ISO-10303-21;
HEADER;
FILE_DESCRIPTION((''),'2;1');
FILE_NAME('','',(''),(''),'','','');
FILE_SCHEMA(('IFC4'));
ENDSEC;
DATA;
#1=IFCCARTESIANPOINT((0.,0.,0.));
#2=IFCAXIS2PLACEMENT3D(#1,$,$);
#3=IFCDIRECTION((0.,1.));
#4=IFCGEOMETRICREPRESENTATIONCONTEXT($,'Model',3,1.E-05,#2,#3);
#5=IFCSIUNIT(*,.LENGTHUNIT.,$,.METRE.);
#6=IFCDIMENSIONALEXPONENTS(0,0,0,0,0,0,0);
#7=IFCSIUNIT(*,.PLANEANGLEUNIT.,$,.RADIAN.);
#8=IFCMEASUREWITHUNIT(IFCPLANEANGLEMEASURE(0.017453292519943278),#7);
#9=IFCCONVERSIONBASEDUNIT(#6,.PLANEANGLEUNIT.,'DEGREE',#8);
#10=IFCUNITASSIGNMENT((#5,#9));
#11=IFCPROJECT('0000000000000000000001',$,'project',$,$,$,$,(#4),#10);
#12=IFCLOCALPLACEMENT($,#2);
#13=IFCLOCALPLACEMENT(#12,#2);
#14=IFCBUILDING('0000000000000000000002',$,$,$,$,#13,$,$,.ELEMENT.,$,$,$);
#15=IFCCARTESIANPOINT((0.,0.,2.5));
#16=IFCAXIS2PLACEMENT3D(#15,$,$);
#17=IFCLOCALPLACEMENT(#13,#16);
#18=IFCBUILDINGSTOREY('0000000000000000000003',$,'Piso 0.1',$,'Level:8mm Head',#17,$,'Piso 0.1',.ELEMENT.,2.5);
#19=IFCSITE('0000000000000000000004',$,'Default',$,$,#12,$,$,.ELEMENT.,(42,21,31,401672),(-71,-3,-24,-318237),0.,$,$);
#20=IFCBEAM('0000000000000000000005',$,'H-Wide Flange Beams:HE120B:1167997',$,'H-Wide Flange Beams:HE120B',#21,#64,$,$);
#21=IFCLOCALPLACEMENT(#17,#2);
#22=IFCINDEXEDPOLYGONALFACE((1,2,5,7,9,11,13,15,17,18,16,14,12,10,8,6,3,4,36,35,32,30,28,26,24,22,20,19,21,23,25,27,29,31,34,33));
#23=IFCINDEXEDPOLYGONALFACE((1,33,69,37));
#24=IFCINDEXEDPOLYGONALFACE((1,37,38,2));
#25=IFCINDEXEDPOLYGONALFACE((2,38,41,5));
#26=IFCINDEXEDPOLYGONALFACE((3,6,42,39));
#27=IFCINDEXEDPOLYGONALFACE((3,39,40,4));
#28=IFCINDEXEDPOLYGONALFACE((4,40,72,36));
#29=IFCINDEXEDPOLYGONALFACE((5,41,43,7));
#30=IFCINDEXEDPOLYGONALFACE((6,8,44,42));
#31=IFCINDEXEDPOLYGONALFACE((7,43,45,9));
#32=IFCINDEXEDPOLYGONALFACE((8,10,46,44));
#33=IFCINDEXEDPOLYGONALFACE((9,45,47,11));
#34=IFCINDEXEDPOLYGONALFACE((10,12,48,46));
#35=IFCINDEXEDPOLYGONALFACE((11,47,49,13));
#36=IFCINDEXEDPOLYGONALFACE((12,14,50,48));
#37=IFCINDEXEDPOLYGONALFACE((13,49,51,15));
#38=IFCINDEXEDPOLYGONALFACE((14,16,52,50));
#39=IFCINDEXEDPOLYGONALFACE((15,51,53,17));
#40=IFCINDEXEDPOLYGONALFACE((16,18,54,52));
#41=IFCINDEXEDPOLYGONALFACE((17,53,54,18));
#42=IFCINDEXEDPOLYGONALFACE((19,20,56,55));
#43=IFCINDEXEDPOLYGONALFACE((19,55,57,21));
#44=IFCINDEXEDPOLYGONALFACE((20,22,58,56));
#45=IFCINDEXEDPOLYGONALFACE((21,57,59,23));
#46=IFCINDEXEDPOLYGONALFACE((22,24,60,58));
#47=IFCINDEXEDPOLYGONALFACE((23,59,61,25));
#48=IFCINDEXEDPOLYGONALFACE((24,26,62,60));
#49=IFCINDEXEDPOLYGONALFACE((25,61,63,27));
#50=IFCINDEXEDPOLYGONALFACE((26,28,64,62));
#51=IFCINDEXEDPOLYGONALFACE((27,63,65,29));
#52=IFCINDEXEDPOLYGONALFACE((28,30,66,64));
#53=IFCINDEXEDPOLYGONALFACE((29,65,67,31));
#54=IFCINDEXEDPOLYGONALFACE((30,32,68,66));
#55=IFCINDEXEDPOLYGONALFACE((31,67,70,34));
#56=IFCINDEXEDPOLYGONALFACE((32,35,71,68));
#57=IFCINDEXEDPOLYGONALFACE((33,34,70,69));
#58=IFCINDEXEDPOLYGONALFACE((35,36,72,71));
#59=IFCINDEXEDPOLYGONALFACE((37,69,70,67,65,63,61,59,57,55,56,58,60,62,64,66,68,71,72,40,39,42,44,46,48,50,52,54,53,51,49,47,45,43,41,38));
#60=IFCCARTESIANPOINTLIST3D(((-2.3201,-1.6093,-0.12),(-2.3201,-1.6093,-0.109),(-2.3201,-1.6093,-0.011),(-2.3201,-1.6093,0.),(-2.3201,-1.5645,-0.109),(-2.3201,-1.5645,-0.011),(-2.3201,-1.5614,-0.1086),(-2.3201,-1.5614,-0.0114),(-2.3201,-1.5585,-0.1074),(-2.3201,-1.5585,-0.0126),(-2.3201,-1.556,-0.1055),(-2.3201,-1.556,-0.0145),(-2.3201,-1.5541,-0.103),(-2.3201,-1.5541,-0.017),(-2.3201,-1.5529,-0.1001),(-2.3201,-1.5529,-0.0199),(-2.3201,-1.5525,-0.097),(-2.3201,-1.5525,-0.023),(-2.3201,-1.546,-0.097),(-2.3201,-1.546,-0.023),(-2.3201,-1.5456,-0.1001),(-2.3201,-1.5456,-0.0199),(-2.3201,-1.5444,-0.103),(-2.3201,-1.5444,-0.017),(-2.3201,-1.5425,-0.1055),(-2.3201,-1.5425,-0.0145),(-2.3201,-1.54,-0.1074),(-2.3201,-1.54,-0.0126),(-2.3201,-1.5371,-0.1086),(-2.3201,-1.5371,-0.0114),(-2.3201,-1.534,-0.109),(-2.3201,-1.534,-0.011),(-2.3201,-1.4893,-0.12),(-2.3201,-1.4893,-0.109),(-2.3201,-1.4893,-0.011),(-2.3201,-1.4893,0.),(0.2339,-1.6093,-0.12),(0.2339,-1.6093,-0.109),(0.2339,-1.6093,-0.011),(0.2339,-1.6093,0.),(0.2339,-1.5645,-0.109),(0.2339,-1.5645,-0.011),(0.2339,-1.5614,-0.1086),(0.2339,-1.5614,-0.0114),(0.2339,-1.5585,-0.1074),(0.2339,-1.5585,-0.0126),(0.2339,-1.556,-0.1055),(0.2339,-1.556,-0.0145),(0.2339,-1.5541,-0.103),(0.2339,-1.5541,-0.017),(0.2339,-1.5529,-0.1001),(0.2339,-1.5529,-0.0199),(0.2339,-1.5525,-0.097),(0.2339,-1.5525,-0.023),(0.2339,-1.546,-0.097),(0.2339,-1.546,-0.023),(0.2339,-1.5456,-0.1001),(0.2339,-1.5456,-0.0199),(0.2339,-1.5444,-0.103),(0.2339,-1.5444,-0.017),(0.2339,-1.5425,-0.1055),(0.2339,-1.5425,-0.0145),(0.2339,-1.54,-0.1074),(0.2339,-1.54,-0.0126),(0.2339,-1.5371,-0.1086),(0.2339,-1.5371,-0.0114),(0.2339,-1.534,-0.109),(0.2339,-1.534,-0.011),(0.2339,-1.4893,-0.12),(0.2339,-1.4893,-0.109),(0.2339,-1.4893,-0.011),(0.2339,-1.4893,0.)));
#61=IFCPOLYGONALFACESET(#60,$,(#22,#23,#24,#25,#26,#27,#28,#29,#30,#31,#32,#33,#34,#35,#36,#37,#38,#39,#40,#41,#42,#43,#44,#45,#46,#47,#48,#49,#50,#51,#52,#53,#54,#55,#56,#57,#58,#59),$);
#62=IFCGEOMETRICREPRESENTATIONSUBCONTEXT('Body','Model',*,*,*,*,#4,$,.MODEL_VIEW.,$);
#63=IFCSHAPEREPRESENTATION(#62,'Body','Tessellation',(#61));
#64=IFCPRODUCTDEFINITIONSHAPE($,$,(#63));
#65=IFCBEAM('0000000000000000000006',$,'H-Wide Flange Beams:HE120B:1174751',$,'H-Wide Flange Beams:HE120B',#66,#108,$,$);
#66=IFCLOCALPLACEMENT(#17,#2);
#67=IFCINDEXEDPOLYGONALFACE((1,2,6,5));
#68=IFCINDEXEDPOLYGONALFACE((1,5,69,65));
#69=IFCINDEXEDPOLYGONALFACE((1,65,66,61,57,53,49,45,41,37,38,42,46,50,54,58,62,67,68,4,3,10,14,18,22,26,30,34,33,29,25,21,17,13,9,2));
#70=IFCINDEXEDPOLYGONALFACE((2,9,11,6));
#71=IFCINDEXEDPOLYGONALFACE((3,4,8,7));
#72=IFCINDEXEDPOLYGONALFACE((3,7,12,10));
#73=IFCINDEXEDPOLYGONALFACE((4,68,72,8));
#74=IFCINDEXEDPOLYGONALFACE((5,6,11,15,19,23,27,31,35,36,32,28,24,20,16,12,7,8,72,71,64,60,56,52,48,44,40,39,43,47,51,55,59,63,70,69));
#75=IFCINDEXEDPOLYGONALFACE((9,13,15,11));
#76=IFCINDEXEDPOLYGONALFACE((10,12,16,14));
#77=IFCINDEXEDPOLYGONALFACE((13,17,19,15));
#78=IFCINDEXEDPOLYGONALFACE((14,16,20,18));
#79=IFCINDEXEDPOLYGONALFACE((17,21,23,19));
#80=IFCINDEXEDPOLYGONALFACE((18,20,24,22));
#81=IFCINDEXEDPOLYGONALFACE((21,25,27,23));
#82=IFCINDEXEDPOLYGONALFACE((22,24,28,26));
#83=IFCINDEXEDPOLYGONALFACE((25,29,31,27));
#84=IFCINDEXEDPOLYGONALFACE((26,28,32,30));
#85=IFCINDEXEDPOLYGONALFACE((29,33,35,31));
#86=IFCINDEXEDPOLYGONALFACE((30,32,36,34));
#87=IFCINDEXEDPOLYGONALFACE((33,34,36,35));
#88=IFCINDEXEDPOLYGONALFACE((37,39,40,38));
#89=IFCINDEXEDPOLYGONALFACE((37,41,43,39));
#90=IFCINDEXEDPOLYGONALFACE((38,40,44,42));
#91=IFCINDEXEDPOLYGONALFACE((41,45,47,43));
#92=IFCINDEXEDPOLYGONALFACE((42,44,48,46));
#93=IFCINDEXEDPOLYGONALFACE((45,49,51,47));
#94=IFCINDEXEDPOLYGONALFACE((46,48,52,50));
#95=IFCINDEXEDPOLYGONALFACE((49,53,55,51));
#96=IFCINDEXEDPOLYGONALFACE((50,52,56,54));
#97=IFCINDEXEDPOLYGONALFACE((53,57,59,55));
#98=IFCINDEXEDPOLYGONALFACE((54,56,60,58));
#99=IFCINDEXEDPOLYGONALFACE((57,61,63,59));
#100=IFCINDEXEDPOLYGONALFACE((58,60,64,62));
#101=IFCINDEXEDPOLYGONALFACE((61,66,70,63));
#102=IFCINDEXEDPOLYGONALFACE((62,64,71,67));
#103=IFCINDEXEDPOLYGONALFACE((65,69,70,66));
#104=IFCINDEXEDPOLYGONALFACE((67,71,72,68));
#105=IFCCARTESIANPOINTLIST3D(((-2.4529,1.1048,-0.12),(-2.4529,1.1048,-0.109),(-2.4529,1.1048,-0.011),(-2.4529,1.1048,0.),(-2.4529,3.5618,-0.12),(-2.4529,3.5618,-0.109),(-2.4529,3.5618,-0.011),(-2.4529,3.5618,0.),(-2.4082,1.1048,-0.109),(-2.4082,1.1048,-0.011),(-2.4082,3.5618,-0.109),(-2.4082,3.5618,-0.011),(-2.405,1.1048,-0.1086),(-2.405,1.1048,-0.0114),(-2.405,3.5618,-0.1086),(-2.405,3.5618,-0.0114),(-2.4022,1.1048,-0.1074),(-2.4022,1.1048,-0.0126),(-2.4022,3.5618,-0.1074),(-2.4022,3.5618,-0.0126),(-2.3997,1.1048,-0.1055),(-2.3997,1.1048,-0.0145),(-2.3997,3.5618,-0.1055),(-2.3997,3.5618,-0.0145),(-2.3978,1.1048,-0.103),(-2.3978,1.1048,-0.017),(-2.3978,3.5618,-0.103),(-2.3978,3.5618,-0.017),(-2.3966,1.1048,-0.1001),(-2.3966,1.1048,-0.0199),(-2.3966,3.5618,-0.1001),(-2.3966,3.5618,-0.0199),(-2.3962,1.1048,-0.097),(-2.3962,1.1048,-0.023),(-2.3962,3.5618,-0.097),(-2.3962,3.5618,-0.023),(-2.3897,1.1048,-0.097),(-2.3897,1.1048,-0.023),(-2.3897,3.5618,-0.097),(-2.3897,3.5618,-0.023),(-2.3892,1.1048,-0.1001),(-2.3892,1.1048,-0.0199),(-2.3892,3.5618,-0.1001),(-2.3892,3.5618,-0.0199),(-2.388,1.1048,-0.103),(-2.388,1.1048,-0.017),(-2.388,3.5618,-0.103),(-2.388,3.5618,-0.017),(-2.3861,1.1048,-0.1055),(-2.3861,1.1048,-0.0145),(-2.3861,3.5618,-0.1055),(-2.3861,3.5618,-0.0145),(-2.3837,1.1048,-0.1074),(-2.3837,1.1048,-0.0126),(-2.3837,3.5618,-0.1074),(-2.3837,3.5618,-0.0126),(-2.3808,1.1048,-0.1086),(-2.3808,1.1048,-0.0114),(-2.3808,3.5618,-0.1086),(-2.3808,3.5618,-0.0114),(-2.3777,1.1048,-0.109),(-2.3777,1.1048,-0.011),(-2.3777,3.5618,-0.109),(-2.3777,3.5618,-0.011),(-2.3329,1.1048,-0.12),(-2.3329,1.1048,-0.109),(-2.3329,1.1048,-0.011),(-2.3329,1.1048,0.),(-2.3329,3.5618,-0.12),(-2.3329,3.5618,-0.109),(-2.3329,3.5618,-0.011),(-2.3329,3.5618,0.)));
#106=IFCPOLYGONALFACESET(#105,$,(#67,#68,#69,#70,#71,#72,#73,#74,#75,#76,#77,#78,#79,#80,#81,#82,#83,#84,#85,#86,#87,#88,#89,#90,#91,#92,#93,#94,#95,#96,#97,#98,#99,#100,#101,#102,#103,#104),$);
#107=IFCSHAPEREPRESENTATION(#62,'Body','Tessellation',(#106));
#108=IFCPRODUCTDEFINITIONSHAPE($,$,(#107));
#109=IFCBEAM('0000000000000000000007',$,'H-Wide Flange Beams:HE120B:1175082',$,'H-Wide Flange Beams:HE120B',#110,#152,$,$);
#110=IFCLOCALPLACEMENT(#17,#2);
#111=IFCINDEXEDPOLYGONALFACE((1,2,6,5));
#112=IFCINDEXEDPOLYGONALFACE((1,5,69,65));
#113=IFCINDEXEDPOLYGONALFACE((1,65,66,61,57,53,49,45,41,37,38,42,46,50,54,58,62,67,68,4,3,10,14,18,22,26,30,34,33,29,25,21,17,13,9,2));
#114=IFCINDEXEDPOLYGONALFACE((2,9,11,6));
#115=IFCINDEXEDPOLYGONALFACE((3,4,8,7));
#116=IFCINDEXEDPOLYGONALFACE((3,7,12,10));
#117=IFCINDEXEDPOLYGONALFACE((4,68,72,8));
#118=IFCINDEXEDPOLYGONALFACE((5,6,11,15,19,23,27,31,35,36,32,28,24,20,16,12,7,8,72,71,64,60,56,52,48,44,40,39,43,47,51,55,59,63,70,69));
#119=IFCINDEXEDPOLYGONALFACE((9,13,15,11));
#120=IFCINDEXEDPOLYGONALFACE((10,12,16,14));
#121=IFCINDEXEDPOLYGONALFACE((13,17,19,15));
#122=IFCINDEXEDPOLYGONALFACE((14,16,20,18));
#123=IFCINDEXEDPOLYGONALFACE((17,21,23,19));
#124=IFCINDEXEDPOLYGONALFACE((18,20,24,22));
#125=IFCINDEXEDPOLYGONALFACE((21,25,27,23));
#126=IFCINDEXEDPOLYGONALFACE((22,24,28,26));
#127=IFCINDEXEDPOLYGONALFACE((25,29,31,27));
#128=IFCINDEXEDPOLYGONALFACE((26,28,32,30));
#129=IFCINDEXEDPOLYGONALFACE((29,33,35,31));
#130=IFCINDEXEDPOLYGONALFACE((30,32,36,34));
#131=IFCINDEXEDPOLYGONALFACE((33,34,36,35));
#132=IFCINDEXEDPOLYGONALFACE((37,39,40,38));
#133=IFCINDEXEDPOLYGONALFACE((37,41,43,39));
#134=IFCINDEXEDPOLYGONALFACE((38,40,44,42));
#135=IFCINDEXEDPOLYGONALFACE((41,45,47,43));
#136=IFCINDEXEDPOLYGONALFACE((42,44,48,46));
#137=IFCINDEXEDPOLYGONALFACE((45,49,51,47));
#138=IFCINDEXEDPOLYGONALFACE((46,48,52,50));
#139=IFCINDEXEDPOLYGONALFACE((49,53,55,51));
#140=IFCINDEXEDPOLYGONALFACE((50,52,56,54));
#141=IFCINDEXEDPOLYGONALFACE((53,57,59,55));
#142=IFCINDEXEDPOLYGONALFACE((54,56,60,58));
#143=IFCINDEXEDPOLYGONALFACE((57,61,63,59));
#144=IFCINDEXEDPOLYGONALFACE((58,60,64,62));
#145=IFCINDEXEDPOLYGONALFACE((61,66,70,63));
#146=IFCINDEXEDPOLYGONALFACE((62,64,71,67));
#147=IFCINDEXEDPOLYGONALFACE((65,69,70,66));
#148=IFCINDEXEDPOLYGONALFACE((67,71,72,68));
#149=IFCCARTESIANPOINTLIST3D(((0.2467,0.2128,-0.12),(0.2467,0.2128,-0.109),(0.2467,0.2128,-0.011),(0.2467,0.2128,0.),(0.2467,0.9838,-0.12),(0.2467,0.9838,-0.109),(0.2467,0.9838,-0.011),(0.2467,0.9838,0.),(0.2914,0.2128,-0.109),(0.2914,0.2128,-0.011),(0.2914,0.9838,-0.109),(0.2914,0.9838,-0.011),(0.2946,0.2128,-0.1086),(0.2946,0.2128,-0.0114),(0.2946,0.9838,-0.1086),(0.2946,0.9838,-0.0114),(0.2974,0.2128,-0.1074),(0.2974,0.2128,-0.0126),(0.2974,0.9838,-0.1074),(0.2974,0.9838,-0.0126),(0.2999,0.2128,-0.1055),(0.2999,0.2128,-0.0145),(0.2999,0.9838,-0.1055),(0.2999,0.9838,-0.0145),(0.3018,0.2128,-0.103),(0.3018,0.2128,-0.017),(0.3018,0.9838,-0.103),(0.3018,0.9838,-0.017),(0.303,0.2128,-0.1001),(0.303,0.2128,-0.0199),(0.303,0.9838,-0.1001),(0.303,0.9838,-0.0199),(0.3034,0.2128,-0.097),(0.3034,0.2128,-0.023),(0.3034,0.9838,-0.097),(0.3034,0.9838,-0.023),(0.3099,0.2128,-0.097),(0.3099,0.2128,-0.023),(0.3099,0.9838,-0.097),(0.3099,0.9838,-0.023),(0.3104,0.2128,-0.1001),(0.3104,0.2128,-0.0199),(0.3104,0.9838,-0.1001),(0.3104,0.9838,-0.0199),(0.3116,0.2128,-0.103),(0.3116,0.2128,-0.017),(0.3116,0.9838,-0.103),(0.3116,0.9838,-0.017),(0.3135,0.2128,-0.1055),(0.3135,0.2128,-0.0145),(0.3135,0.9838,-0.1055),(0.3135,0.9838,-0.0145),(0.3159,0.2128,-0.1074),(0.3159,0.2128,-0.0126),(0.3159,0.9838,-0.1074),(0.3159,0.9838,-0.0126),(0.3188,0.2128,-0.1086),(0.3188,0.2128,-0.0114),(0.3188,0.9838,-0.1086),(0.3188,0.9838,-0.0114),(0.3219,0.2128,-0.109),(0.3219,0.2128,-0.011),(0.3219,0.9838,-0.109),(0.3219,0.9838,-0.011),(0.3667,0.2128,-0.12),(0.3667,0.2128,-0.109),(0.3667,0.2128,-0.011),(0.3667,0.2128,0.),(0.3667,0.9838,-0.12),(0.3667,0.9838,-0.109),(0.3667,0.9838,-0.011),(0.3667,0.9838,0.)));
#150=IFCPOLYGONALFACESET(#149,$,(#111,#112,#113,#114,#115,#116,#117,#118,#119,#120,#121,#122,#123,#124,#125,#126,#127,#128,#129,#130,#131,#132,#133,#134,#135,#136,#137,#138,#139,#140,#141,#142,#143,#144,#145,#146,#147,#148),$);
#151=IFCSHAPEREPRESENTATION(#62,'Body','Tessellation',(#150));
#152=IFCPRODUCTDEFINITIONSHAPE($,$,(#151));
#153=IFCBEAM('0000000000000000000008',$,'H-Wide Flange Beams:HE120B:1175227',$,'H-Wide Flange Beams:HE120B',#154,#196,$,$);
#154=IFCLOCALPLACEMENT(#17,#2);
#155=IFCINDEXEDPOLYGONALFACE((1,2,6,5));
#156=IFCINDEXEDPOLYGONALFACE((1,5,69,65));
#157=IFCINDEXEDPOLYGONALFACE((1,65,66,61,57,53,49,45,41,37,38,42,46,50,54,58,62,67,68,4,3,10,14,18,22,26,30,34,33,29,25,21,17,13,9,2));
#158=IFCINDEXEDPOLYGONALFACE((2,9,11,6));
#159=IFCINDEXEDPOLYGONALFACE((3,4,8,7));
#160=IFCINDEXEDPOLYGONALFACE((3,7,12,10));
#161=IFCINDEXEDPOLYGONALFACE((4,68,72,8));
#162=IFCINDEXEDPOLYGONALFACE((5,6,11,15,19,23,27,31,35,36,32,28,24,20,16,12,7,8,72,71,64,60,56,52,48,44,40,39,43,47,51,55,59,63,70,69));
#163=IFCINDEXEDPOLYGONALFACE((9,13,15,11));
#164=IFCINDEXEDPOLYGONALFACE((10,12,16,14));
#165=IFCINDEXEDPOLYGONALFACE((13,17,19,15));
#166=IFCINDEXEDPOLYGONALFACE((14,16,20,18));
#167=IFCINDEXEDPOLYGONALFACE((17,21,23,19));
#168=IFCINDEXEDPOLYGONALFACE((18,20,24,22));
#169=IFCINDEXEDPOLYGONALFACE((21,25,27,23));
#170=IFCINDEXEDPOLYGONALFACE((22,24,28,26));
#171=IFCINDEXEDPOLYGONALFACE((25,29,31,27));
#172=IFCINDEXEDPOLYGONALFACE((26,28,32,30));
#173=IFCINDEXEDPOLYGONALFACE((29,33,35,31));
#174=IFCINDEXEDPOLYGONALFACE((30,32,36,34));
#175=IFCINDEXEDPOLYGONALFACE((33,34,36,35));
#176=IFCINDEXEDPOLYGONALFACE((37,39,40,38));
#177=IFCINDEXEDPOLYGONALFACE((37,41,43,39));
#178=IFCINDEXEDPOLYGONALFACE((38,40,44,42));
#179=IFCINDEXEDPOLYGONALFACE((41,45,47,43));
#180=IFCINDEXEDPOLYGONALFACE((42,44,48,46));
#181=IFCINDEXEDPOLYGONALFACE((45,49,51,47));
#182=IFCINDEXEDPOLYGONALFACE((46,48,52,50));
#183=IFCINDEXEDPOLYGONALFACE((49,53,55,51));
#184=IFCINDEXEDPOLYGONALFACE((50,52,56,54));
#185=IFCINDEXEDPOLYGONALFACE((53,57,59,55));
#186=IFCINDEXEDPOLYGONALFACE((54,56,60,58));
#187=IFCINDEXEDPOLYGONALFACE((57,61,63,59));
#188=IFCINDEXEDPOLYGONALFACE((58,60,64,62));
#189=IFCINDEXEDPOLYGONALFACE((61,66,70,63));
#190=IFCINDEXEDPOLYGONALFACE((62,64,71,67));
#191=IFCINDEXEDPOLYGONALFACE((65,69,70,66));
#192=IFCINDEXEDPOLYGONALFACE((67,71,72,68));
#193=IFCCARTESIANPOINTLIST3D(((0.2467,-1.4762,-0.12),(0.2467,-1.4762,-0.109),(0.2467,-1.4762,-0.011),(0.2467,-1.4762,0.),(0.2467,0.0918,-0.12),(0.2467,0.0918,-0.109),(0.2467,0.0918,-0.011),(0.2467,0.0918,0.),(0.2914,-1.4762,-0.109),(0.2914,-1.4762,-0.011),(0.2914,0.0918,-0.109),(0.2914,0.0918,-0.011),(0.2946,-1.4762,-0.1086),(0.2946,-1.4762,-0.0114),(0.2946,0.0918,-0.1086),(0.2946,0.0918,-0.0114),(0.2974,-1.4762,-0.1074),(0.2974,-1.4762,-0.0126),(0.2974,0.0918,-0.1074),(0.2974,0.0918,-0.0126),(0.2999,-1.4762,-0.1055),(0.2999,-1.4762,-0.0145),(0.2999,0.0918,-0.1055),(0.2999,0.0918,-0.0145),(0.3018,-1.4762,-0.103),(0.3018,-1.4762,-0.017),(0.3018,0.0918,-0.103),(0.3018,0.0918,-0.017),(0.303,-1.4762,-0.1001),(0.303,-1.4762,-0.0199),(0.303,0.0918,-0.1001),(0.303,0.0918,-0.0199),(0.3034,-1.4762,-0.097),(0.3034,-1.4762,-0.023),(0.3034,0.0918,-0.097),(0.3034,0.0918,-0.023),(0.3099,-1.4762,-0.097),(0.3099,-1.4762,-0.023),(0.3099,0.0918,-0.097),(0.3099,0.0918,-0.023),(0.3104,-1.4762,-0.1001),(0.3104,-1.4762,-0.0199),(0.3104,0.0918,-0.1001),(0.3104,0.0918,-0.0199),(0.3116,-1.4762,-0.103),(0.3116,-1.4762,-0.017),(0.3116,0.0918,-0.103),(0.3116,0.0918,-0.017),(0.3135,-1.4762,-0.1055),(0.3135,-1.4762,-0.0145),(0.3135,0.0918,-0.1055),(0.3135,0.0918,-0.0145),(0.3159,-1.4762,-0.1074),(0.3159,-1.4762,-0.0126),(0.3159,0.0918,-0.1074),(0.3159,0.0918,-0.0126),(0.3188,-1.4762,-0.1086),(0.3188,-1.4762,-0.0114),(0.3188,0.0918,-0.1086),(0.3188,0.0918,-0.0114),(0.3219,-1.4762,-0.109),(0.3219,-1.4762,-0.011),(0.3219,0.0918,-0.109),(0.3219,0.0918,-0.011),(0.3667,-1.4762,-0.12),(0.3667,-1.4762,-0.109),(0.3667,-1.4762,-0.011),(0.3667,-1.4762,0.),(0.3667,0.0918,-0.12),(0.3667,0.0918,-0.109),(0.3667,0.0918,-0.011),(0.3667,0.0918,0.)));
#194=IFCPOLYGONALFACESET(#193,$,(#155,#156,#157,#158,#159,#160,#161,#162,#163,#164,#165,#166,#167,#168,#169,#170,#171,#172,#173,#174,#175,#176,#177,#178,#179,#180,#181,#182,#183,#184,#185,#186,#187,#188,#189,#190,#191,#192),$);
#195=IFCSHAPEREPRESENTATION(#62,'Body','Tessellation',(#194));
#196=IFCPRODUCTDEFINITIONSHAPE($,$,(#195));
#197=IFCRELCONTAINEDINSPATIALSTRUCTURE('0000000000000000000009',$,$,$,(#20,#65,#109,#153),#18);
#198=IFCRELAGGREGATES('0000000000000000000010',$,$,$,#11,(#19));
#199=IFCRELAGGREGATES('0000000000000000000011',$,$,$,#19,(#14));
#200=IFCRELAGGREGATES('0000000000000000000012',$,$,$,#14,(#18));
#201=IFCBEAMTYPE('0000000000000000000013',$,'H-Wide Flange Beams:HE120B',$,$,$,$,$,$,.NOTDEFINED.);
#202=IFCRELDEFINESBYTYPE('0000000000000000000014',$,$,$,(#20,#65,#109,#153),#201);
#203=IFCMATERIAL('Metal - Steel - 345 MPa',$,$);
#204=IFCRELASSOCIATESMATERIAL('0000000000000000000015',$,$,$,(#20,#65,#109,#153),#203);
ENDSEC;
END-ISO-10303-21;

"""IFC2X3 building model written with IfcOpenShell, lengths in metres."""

from ifc_helpers import new_model, entity, si_unit, converted_unit, direction, frame, frame_2d, origin, place, context, subcontext, project, spatial, i_section, extrude, material, type_object, element, save


model = new_model("IFC2X3")

# Units and contexts
model_context = context("Model", 3, precision=1e-05, world=origin(), true_north=direction((0.0, 1.0)))
body_context = subcontext(model_context, "Body", "Model", "MODEL_VIEW")
ifc_project = project(units=[si_unit("LENGTHUNIT", "METRE"), converted_unit("PLANEANGLEUNIT", "DEGREE", entity("IfcPlaneAngleMeasure", 0.017453292519943278), si_unit("PLANEANGLEUNIT", "RADIAN"), dimensions=[0, 0, 0, 0, 0, 0, 0])], contexts=[model_context])

# Site, building, storey
site_placement = place(None, origin())
site = spatial("IfcSite", under=ifc_project, at=site_placement, Name="Default", CompositionType="ELEMENT", RefLatitude=(42, 21, 31, 401672), RefLongitude=(-71, -3, -24, -318237), RefElevation=0.0)
building_placement = place(site_placement, origin())
building = spatial("IfcBuilding", under=site, at=building_placement, CompositionType="ELEMENT")
storey_placement = place(building_placement, frame((0.0, 0.0, 2.5)))
storey = spatial("IfcBuildingStorey", under=building, at=storey_placement, Name="Piso 0.1", ObjectType="Level:8mm Head", LongName="Piso 0.1", CompositionType="ELEMENT", Elevation=2.5)

# Shared definitions
ifc_material_1 = material(Name="Metal - Steel - 345 MPa")

# Beams
beam_type = type_object("IfcBeamType", Name="H-Wide Flange Beams:HE120B", PredefinedType="NOTDEFINED")
beam_1_placement = place(storey_placement, frame((0.3067, -1.5493, 0.0), z_axis=(0.0, 0.0, 1.0), x_axis=(-1.0, 0.0, 0.0)))
element("IfcBeam", 1, at=beam_1_placement, inside=storey, type_object=beam_type, material=ifc_material_1, Name="H-Wide Flange Beams:HE120B:1167997", ObjectType="H-Wide Flange Beams:HE120B", context=body_context, shape_type="SweptSolid", body=[
    extrude(i_section(OverallWidth=0.12, OverallDepth=0.12, WebThickness=0.0065, FlangeThickness=0.011, FilletRadius=0.012, at=frame_2d((0.0, 0.0), x_axis=(0.0, 1.0))), frame((0.0728, 0.0, -0.06), z_axis=(1.0, 0.0, 0.0), x_axis=(0.0, 0.0, -1.0)), (0.0, 0.0, 1.0), 2.554),
])
beam_2_placement = place(storey_placement, frame((-2.3929, 1.0358, 0.0), z_axis=(0.0, 0.0, 1.0), x_axis=(0.0, 1.0, 0.0)))
element("IfcBeam", 2, at=beam_2_placement, inside=storey, type_object=beam_type, material=ifc_material_1, Name="H-Wide Flange Beams:HE120B:1174751", ObjectType="H-Wide Flange Beams:HE120B", context=body_context, shape_type="SweptSolid", body=[
    extrude(i_section(OverallWidth=0.12, OverallDepth=0.12, WebThickness=0.0065, FlangeThickness=0.011, FilletRadius=0.012, at=frame_2d((0.0, 0.0), x_axis=(0.0, 1.0))), frame((0.069, 0.0, -0.06), z_axis=(1.0, 0.0, 0.0), x_axis=(0.0, 0.0, -1.0)), (0.0, 0.0, 1.0), 2.457),
])
beam_3_placement = place(storey_placement, frame((0.3067, 1.0548, 0.0), z_axis=(0.0, 0.0, 1.0), x_axis=(0.0, -1.0, 0.0)))
element("IfcBeam", 3, at=beam_3_placement, inside=storey, type_object=beam_type, material=ifc_material_1, Name="H-Wide Flange Beams:HE120B:1175082", ObjectType="H-Wide Flange Beams:HE120B", context=body_context, shape_type="SweptSolid", body=[
    extrude(i_section(OverallWidth=0.12, OverallDepth=0.12, WebThickness=0.0065, FlangeThickness=0.011, FilletRadius=0.012, at=frame_2d((0.0, 0.0), x_axis=(0.0, 1.0))), frame((0.071, 0.0, -0.06), z_axis=(1.0, 0.0, 0.0), x_axis=(0.0, 0.0, -1.0)), (0.0, 0.0, 1.0), 0.771),
])
beam_4_placement = place(storey_placement, frame((0.3067, 0.1498, 0.0), z_axis=(0.0, 0.0, 1.0), x_axis=(0.0, -1.0, 0.0)))
element("IfcBeam", 4, at=beam_4_placement, inside=storey, type_object=beam_type, material=ifc_material_1, Name="H-Wide Flange Beams:HE120B:1175227", ObjectType="H-Wide Flange Beams:HE120B", context=body_context, shape_type="SweptSolid", body=[
    extrude(i_section(OverallWidth=0.12, OverallDepth=0.12, WebThickness=0.0065, FlangeThickness=0.011, FilletRadius=0.012, at=frame_2d((0.0, 0.0), x_axis=(0.0, 1.0))), frame((0.058, 0.0, -0.06), z_axis=(1.0, 0.0, 0.0), x_axis=(0.0, 0.0, -1.0)), (0.0, 0.0, 1.0), 1.568),
])

save(model, "model.ifc")
